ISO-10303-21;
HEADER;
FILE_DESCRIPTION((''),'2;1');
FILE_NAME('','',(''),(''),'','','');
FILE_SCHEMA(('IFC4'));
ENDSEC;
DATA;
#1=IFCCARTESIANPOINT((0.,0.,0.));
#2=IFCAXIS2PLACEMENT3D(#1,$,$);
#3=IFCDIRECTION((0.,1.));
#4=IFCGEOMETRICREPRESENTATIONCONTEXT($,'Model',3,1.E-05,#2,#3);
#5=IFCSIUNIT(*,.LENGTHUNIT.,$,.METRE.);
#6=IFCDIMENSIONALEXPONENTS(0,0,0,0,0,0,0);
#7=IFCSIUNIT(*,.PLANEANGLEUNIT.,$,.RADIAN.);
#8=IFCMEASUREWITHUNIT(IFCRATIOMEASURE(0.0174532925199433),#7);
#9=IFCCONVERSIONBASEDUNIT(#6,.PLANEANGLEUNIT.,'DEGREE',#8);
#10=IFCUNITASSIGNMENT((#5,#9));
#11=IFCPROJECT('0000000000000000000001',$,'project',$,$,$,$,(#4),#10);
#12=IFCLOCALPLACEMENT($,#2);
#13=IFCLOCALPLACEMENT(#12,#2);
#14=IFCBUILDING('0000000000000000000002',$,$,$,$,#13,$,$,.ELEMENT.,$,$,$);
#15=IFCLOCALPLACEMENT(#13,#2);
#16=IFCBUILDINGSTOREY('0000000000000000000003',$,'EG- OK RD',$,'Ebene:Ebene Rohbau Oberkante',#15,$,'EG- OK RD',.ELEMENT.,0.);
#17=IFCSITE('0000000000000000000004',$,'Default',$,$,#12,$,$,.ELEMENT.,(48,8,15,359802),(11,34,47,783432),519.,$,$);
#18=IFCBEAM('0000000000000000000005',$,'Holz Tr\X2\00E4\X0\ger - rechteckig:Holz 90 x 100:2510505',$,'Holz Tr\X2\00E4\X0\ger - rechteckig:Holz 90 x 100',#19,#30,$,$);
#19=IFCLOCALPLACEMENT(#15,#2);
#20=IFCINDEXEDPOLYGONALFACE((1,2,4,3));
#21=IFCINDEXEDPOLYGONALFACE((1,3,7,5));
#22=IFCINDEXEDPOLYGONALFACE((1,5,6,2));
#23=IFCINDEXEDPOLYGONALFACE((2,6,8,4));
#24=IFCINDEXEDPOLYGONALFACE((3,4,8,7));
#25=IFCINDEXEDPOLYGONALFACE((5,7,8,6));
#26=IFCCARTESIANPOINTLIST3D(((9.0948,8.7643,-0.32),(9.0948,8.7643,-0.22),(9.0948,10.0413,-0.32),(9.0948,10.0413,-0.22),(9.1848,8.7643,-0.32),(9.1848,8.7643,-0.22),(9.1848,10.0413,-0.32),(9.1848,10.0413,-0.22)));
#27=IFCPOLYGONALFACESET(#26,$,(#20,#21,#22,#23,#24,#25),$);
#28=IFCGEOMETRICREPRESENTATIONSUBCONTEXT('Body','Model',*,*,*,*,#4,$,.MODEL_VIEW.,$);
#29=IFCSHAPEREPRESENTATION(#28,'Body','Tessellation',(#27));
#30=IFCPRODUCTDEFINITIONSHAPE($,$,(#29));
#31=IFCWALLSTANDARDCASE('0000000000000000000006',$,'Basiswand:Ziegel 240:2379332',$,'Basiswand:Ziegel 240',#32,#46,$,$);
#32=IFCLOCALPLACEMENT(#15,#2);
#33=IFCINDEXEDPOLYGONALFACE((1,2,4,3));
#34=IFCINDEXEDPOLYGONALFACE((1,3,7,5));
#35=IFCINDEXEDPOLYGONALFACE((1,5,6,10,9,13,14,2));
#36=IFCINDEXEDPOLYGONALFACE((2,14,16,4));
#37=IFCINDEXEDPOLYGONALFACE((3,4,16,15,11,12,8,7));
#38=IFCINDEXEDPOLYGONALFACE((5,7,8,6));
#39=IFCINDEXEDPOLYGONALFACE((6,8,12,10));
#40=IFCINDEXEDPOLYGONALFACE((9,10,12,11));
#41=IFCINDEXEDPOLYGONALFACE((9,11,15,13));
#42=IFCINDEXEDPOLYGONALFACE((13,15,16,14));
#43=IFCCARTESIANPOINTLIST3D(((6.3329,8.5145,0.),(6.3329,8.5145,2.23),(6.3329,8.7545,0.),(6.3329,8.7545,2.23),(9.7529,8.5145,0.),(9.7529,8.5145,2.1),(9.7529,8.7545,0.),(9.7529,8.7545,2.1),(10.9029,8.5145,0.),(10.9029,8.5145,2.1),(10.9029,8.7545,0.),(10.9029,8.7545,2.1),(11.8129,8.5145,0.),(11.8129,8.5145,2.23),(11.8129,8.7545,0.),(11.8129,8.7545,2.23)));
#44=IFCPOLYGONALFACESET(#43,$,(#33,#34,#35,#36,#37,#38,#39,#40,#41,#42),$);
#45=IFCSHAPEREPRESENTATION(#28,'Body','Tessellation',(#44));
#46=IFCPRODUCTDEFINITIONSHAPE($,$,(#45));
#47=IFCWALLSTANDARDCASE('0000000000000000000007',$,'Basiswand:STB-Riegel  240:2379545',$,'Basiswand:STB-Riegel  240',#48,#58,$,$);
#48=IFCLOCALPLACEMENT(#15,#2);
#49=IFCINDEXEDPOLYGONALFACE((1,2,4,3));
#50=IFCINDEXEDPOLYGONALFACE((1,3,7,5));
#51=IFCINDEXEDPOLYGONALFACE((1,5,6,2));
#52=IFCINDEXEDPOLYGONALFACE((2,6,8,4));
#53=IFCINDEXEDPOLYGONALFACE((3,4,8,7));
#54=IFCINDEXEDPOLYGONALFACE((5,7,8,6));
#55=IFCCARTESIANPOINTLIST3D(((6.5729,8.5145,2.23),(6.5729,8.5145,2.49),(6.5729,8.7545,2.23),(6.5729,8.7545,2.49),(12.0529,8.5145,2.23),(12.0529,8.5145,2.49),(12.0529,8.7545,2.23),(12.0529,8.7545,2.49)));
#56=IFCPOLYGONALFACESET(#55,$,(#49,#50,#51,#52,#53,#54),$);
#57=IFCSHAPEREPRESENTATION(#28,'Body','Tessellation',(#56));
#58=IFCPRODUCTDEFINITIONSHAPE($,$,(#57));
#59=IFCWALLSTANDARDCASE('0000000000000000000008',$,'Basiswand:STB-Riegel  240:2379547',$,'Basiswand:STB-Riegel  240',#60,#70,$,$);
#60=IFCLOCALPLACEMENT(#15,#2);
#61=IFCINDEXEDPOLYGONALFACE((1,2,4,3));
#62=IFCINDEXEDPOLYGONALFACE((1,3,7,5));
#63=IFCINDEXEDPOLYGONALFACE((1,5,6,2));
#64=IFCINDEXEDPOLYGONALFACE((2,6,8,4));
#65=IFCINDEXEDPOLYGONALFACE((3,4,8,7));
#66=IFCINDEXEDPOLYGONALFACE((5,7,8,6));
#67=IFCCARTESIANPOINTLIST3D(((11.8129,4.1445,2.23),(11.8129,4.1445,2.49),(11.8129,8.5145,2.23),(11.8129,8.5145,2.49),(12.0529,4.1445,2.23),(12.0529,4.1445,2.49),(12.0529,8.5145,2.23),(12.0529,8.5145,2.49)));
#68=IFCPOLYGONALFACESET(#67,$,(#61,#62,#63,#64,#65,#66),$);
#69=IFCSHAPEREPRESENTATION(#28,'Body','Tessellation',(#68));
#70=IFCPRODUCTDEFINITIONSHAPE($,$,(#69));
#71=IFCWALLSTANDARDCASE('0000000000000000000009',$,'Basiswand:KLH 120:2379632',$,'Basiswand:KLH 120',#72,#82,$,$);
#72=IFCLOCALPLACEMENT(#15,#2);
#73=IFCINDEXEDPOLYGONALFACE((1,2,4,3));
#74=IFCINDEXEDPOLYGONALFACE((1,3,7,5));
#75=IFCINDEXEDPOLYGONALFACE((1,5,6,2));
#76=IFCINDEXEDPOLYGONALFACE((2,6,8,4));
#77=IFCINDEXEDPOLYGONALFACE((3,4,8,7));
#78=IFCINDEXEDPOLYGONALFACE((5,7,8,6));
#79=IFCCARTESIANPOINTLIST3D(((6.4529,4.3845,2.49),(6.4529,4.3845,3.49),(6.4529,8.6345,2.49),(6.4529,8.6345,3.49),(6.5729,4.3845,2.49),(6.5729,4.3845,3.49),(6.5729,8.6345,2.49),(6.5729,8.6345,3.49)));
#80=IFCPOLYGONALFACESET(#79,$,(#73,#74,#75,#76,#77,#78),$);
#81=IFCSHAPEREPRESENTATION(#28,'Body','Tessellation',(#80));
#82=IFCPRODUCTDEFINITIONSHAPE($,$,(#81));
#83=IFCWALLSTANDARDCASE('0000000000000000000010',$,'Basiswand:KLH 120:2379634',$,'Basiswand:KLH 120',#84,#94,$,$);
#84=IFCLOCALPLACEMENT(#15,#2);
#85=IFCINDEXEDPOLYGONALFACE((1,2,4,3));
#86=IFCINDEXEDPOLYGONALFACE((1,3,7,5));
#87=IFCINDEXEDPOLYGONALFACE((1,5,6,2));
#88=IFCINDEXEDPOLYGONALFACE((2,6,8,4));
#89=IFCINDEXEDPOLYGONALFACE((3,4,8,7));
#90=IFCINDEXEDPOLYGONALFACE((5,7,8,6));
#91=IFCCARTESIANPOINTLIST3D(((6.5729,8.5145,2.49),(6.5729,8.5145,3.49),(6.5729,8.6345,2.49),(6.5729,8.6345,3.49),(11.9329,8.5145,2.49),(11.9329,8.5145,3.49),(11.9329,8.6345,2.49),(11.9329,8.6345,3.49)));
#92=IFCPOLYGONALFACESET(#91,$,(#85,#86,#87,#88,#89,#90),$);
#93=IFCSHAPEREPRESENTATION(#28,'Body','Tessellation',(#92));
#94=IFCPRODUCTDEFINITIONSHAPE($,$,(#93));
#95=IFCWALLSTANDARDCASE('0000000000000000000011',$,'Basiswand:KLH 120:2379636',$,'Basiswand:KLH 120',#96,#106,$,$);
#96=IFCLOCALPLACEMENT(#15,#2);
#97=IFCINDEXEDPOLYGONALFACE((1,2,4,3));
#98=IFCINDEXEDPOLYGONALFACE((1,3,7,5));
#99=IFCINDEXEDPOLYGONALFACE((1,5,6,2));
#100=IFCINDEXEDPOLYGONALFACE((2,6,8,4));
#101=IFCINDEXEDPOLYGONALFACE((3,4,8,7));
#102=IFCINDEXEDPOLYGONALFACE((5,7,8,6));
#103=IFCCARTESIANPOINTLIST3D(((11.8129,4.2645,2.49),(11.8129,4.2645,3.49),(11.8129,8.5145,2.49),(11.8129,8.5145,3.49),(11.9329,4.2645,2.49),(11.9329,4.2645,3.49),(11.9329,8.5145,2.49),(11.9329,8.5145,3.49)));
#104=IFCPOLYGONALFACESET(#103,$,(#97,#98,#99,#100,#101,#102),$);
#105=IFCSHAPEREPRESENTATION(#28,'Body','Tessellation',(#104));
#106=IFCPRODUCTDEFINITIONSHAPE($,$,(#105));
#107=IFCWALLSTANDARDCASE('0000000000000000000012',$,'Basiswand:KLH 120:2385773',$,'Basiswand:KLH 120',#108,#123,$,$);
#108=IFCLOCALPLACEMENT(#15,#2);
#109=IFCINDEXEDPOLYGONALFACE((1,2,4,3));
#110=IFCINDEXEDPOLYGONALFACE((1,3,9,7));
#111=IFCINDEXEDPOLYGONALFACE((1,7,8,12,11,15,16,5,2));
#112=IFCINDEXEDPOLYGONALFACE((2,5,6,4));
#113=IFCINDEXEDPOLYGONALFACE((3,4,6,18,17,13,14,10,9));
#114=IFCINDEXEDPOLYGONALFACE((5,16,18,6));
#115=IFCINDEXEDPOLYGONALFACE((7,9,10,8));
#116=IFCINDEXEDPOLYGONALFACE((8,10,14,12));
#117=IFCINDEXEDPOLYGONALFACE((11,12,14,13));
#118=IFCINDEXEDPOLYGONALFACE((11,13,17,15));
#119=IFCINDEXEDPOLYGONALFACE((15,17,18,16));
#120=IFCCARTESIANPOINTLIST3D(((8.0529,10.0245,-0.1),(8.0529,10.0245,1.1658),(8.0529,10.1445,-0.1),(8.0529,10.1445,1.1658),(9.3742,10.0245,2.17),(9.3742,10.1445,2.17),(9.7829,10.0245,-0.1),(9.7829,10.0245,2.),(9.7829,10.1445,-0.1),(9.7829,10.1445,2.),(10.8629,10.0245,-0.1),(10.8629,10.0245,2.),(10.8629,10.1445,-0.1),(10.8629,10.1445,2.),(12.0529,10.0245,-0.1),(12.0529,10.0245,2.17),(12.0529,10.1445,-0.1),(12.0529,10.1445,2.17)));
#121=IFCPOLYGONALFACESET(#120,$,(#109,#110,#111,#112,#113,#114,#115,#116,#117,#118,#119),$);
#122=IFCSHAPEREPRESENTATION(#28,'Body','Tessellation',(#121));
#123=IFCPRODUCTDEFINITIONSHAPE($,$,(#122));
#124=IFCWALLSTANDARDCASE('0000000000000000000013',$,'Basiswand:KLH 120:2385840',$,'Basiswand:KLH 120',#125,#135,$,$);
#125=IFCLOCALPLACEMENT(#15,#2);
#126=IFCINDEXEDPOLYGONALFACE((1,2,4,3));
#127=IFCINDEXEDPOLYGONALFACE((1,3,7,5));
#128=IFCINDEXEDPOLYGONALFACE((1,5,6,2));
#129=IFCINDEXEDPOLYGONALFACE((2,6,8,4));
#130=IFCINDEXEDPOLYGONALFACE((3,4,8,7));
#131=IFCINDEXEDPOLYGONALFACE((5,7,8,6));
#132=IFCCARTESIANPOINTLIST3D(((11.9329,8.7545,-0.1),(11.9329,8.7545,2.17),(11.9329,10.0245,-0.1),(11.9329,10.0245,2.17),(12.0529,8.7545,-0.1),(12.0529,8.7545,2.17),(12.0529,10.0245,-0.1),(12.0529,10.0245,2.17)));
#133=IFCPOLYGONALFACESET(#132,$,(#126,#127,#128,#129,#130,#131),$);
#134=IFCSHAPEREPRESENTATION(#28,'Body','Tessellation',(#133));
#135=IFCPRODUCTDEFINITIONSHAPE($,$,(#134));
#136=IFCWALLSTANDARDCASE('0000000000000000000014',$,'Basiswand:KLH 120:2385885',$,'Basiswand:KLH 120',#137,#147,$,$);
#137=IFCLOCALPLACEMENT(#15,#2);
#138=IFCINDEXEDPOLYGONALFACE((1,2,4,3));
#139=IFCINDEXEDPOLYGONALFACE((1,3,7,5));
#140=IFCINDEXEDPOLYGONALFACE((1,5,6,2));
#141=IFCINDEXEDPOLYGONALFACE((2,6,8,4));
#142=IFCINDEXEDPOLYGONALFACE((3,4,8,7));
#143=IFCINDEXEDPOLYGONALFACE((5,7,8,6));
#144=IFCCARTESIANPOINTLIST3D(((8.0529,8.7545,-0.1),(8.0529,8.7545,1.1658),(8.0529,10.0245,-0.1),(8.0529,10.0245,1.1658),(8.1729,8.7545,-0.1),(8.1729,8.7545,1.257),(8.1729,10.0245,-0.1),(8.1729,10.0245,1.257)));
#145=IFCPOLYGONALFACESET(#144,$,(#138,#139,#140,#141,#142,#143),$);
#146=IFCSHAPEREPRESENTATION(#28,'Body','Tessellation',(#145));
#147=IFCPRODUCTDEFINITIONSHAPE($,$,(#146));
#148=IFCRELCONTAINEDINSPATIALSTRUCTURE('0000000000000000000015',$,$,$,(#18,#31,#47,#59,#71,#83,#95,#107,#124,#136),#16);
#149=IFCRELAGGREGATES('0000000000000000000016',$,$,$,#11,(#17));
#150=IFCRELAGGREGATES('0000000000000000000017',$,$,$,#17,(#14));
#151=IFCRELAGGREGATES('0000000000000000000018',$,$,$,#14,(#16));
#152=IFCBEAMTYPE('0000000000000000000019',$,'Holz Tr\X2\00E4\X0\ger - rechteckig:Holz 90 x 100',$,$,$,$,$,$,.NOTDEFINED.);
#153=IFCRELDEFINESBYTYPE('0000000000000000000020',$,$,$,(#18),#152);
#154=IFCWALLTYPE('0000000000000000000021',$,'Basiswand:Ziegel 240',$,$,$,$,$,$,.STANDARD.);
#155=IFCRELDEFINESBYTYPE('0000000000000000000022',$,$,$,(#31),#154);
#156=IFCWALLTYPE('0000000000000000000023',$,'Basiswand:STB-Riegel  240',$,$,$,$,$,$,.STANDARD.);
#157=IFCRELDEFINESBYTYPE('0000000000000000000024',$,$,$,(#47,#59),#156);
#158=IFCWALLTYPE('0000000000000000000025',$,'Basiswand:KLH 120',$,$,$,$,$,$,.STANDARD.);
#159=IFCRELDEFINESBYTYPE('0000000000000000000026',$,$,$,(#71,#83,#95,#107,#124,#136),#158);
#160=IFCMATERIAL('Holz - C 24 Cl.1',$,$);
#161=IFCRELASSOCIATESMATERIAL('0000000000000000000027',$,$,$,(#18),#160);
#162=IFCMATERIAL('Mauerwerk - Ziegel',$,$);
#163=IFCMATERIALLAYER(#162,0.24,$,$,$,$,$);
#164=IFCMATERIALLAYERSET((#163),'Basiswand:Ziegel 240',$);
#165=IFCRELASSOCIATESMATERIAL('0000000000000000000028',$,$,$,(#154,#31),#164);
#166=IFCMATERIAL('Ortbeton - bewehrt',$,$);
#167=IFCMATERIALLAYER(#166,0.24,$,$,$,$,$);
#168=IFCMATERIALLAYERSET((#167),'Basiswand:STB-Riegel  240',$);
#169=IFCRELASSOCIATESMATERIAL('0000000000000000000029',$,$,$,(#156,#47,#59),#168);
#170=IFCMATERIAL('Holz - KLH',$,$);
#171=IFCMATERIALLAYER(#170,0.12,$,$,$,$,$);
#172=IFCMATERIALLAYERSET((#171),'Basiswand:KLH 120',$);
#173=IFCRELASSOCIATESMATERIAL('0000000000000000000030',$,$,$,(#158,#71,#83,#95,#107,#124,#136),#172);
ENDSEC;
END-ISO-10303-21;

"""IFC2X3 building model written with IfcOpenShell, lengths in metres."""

from ifc_helpers import new_model, entity, si_unit, converted_unit, direction, frame, frame_2d, origin, place, context, subcontext, project, spatial, polyline, rectangle, extrude, clip, bounded_halfspace, material, layer, layer_set, layer_usage, type_object, element, save


model = new_model("IFC2X3")

# Units and contexts
model_context = context("Model", 3, precision=1e-05, world=origin(), true_north=direction((0.0, 1.0)))
body_context = subcontext(model_context, "Body", "Model", "MODEL_VIEW")
ifc_project = project(units=[si_unit("LENGTHUNIT", "METRE"), converted_unit("PLANEANGLEUNIT", "DEGREE", entity("IfcRatioMeasure", 0.0174532925199433), si_unit("PLANEANGLEUNIT", "RADIAN"), dimensions=[0, 0, 0, 0, 0, 0, 0])], contexts=[model_context])

# Site, building, storey
site_placement = place(None, origin())
site = spatial("IfcSite", under=ifc_project, at=site_placement, Name="Default", CompositionType="ELEMENT", RefLatitude=(48, 8, 15, 359802), RefLongitude=(11, 34, 47, 783432), RefElevation=519.0)
building_placement = place(site_placement, origin())
building = spatial("IfcBuilding", under=site, at=building_placement, CompositionType="ELEMENT")
storey_placement = place(building_placement, origin())
storey = spatial("IfcBuildingStorey", under=building, at=storey_placement, Name="EG- OK RD", ObjectType="Ebene:Ebene Rohbau Oberkante", LongName="EG- OK RD", CompositionType="ELEMENT", Elevation=0.0)

# Beam
ifc_material_1 = material(Name="Holz - C 24 Cl.1")
beam_type = type_object("IfcBeamType", Name="Holz Träger - rechteckig:Holz 90 x 100", PredefinedType="NOTDEFINED")
beam_placement = place(storey_placement, frame((9.1398, 10.0415, -0.22), z_axis=(0.0, 0.0, 1.0), x_axis=(0.0, -1.0, 0.0)))
element("IfcBeam", 1, at=beam_placement, inside=storey, type_object=beam_type, material=ifc_material_1, Name="Holz Träger - rechteckig:Holz 90 x 100:2510505", ObjectType="Holz Träger - rechteckig:Holz 90 x 100", context=body_context, shape_type="SweptSolid", body=[
    extrude(rectangle(XDim=0.1, YDim=0.09, at=frame_2d((0.0, 0.0), x_axis=(1.0, 0.0))), frame((0.0003, 0.0, -0.05), z_axis=(1.0, 0.0, 0.0), x_axis=(0.0, 0.0, -1.0)), (0.0, 0.0, 1.0), 1.277),
])

# Shared definitions
ifc_material_2 = material(Name="Mauerwerk - Ziegel")
ifc_layer_1 = layer(ifc_material_2, 0.24)
ifc_layer_set_1 = layer_set([ifc_layer_1], Name="Basiswand:Ziegel 240")
wall_type_1 = type_object("IfcWallType", Name="Basiswand:Ziegel 240", PredefinedType="STANDARD", material=ifc_layer_set_1)

# Wall, opening
ifc_layer_usage_1 = layer_usage(ifc_layer_set_1, "AXIS2", "POSITIVE", -0.12)
wall_1_placement = place(storey_placement, frame((11.8129, 8.6345, 0.0), z_axis=(0.0, 0.0, 1.0), x_axis=(-1.0, 0.0, 0.0)))
wall_1 = element("IfcWallStandardCase", 2, at=wall_1_placement, inside=storey, type_object=wall_type_1, material=ifc_layer_usage_1, Name="Basiswand:Ziegel 240:2379332", ObjectType="Basiswand:Ziegel 240", context=body_context, shape_type="SweptSolid", body=[
    extrude(rectangle(XDim=5.48, YDim=0.24, at=frame_2d((2.74, 0.0), x_axis=(-1.0, 0.0))), origin(), (0.0, 0.0, 1.0), 2.23),
])
opening_1_placement = place(wall_1_placement, frame((0.91, -0.12, 0.0)))
element("IfcOpeningElement", 3, at=opening_1_placement, cuts=wall_1, ObjectType="Opening", context=body_context, shape_type="SweptSolid", body=[
    extrude(rectangle(XDim=2.1, YDim=1.15, at=frame_2d((1.05, 0.575), x_axis=(-1.0, 0.0))), frame((0.0, 0.0, 0.0), z_axis=(0.0, 1.0, 0.0), x_axis=(0.0, 0.0, 1.0)), (0.0, 0.0, 1.0), 0.24),
])

# Walls
ifc_material_3 = material(Name="Ortbeton - bewehrt")
ifc_layer_2 = layer(ifc_material_3, 0.24)
ifc_layer_set_2 = layer_set([ifc_layer_2], Name="Basiswand:STB-Riegel  240")
ifc_layer_usage_2 = layer_usage(ifc_layer_set_2, "AXIS2", "NEGATIVE", 0.12)
wall_type_2 = type_object("IfcWallType", Name="Basiswand:STB-Riegel  240", PredefinedType="STANDARD", material=ifc_layer_set_2)
wall_2_placement = place(storey_placement, frame((12.0529, 8.6345, 2.23), z_axis=(0.0, 0.0, 1.0), x_axis=(-1.0, 0.0, 0.0)))
element("IfcWallStandardCase", 4, at=wall_2_placement, inside=storey, type_object=wall_type_2, material=ifc_layer_usage_2, Name="Basiswand:STB-Riegel  240:2379545", ObjectType="Basiswand:STB-Riegel  240", context=body_context, shape_type="SweptSolid", body=[
    extrude(rectangle(XDim=5.48, YDim=0.24, at=frame_2d((2.74, 0.0), x_axis=(-1.0, 0.0))), origin(), (0.0, 0.0, 1.0), 0.26),
])
ifc_layer_usage_3 = layer_usage(ifc_layer_set_2, "AXIS2", "NEGATIVE", 0.12)
wall_3_placement = place(storey_placement, frame((11.9329, 4.1445, 2.23), z_axis=(0.0, 0.0, 1.0), x_axis=(0.0, 1.0, 0.0)))
element("IfcWallStandardCase", 5, at=wall_3_placement, inside=storey, type_object=wall_type_2, material=ifc_layer_usage_3, Name="Basiswand:STB-Riegel  240:2379547", ObjectType="Basiswand:STB-Riegel  240", context=body_context, shape_type="SweptSolid", body=[
    extrude(rectangle(XDim=4.37, YDim=0.24, at=frame_2d((2.185, 0.0), x_axis=(-1.0, 0.0))), origin(), (0.0, 0.0, 1.0), 0.26),
])
ifc_material_4 = material(Name="Holz - KLH")
ifc_layer_3 = layer(ifc_material_4, 0.12)
ifc_layer_set_3 = layer_set([ifc_layer_3], Name="Basiswand:KLH 120")
ifc_layer_usage_4 = layer_usage(ifc_layer_set_3, "AXIS2", "NEGATIVE", 0.06)
wall_type_3 = type_object("IfcWallType", Name="Basiswand:KLH 120", PredefinedType="STANDARD", material=ifc_layer_set_3)
wall_4_placement = place(storey_placement, frame((6.5129, 8.6345, 2.49), z_axis=(0.0, 0.0, 1.0), x_axis=(0.0, -1.0, 0.0)))
element("IfcWallStandardCase", 6, at=wall_4_placement, inside=storey, type_object=wall_type_3, material=ifc_layer_usage_4, Name="Basiswand:KLH 120:2379632", ObjectType="Basiswand:KLH 120", context=body_context, shape_type="SweptSolid", body=[
    extrude(rectangle(XDim=4.25, YDim=0.12, at=frame_2d((2.125, 0.0), x_axis=(-1.0, 0.0))), origin(), (0.0, 0.0, 1.0), 1.0),
])
ifc_layer_usage_5 = layer_usage(ifc_layer_set_3, "AXIS2", "NEGATIVE", 0.06)
wall_5_placement = place(storey_placement, frame((11.9329, 8.5745, 2.49), z_axis=(0.0, 0.0, 1.0), x_axis=(-1.0, 0.0, 0.0)))
element("IfcWallStandardCase", 7, at=wall_5_placement, inside=storey, type_object=wall_type_3, material=ifc_layer_usage_5, Name="Basiswand:KLH 120:2379634", ObjectType="Basiswand:KLH 120", context=body_context, shape_type="SweptSolid", body=[
    extrude(rectangle(XDim=5.36, YDim=0.12, at=frame_2d((2.68, 0.0), x_axis=(-1.0, 0.0))), origin(), (0.0, 0.0, 1.0), 1.0),
])
ifc_layer_usage_6 = layer_usage(ifc_layer_set_3, "AXIS2", "NEGATIVE", 0.06)
wall_6_placement = place(storey_placement, frame((11.8729, 4.2645, 2.49), z_axis=(0.0, 0.0, 1.0), x_axis=(0.0, 1.0, 0.0)))
element("IfcWallStandardCase", 8, at=wall_6_placement, inside=storey, type_object=wall_type_3, material=ifc_layer_usage_6, Name="Basiswand:KLH 120:2379636", ObjectType="Basiswand:KLH 120", context=body_context, shape_type="SweptSolid", body=[
    extrude(rectangle(XDim=4.25, YDim=0.12, at=frame_2d((2.125, 0.0), x_axis=(-1.0, 0.0))), origin(), (0.0, 0.0, 1.0), 1.0),
])

# Wall, opening
ifc_layer_usage_7 = layer_usage(ifc_layer_set_3, "AXIS2", "POSITIVE", -0.06)
wall_7_placement = place(storey_placement, frame((12.0529, 10.0845, -0.1), z_axis=(0.0, 0.0, 1.0), x_axis=(-1.0, 0.0, 0.0)))
wall_7 = element("IfcWallStandardCase", 9, at=wall_7_placement, inside=storey, type_object=wall_type_3, material=ifc_layer_usage_7, Name="Basiswand:KLH 120:2385773", ObjectType="Basiswand:KLH 120", context=body_context, shape_type="Clipping", body=[
    clip(clip(extrude(rectangle(XDim=4.0, YDim=0.12, at=frame_2d((2.0, 0.0), x_axis=(-1.0, 0.0))), origin(), (0.0, 0.0, 1.0), 2.27), bounded_halfspace(frame((0.0, 0.06, 2.27), z_axis=(0.0, 0.0, -1.0), x_axis=(0.0, 1.0, 0.0)), True, frame((0.0, 0.06, 2.27)), polyline([(0.0, 0.0), (0.0, -0.12), (2.6787, -0.12), (2.6787, 0.0), (0.12, 0.0), (0.0, 0.0)]))), bounded_halfspace(frame((4.0, -0.06, 1.2658), z_axis=(-0.605083, 0.0, -0.796162), x_axis=(0.0, 1.0, 0.0)), True, frame((4.0, -0.06, 1.2658)), polyline([(0.0, 0.0), (0.0, 0.12), (-0.12, 0.12), (-1.3213, 0.12), (-1.3213, 0.0), (0.0, 0.0)]))),
])
opening_2_placement = place(wall_7_placement, frame((1.19, -0.06, 0.0)))
element("IfcOpeningElement", 10, at=opening_2_placement, cuts=wall_7, ObjectType="Opening", context=body_context, shape_type="SweptSolid", body=[
    extrude(rectangle(XDim=2.1, YDim=1.08, at=frame_2d((1.05, 0.54), x_axis=(-1.0, 0.0))), frame((0.0, 0.0, 0.0), z_axis=(0.0, 1.0, 0.0), x_axis=(0.0, 0.0, 1.0)), (0.0, 0.0, 1.0), 0.12),
])

# Walls
ifc_layer_usage_8 = layer_usage(ifc_layer_set_3, "AXIS2", "POSITIVE", -0.06)
wall_8_placement = place(storey_placement, frame((11.9929, 8.7545, -0.1), z_axis=(0.0, 0.0, 1.0), x_axis=(0.0, 1.0, 0.0)))
element("IfcWallStandardCase", 11, at=wall_8_placement, inside=storey, type_object=wall_type_3, material=ifc_layer_usage_8, Name="Basiswand:KLH 120:2385840", ObjectType="Basiswand:KLH 120", context=body_context, shape_type="Clipping", body=[
    clip(extrude(rectangle(XDim=1.27, YDim=0.12, at=frame_2d((0.635, 0.0), x_axis=(-1.0, 0.0))), origin(), (0.0, 0.0, 1.0), 2.27), bounded_halfspace(frame((0.0, -0.06, 2.27), z_axis=(0.0, 0.0, -1.0), x_axis=(-1.0, 0.0, 0.0)), True, frame((0.0, -0.06, 2.27)), polyline([(0.0, 0.0), (1.27, 0.0), (1.27, 0.12), (0.0, 0.12), (0.0, 0.0)]))),
])
ifc_layer_usage_9 = layer_usage(ifc_layer_set_3, "AXIS2", "NEGATIVE", 0.06)
wall_9_placement = place(storey_placement, frame((8.1129, 8.7545, -0.1), z_axis=(0.0, 0.0, 1.0), x_axis=(0.0, 1.0, 0.0)))
element("IfcWallStandardCase", 12, at=wall_9_placement, inside=storey, type_object=wall_type_3, material=ifc_layer_usage_9, Name="Basiswand:KLH 120:2385885", ObjectType="Basiswand:KLH 120", context=body_context, shape_type="Clipping", body=[
    clip(extrude(rectangle(XDim=1.27, YDim=0.12, at=frame_2d((0.635, 0.0), x_axis=(-1.0, 0.0))), origin(), (0.0, 0.0, 1.0), 1.357), bounded_halfspace(frame((0.0, -0.06, 1.357), z_axis=(0.0, -0.605083, -0.796162), x_axis=(-1.0, 0.0, 0.0)), True, frame((0.0, -0.06, 1.357)), polyline([(0.0, 0.0), (1.27, 0.0), (1.27, 0.12), (0.0, 0.12), (0.0, 0.0)]))),
])

save(model, "model.ifc")
